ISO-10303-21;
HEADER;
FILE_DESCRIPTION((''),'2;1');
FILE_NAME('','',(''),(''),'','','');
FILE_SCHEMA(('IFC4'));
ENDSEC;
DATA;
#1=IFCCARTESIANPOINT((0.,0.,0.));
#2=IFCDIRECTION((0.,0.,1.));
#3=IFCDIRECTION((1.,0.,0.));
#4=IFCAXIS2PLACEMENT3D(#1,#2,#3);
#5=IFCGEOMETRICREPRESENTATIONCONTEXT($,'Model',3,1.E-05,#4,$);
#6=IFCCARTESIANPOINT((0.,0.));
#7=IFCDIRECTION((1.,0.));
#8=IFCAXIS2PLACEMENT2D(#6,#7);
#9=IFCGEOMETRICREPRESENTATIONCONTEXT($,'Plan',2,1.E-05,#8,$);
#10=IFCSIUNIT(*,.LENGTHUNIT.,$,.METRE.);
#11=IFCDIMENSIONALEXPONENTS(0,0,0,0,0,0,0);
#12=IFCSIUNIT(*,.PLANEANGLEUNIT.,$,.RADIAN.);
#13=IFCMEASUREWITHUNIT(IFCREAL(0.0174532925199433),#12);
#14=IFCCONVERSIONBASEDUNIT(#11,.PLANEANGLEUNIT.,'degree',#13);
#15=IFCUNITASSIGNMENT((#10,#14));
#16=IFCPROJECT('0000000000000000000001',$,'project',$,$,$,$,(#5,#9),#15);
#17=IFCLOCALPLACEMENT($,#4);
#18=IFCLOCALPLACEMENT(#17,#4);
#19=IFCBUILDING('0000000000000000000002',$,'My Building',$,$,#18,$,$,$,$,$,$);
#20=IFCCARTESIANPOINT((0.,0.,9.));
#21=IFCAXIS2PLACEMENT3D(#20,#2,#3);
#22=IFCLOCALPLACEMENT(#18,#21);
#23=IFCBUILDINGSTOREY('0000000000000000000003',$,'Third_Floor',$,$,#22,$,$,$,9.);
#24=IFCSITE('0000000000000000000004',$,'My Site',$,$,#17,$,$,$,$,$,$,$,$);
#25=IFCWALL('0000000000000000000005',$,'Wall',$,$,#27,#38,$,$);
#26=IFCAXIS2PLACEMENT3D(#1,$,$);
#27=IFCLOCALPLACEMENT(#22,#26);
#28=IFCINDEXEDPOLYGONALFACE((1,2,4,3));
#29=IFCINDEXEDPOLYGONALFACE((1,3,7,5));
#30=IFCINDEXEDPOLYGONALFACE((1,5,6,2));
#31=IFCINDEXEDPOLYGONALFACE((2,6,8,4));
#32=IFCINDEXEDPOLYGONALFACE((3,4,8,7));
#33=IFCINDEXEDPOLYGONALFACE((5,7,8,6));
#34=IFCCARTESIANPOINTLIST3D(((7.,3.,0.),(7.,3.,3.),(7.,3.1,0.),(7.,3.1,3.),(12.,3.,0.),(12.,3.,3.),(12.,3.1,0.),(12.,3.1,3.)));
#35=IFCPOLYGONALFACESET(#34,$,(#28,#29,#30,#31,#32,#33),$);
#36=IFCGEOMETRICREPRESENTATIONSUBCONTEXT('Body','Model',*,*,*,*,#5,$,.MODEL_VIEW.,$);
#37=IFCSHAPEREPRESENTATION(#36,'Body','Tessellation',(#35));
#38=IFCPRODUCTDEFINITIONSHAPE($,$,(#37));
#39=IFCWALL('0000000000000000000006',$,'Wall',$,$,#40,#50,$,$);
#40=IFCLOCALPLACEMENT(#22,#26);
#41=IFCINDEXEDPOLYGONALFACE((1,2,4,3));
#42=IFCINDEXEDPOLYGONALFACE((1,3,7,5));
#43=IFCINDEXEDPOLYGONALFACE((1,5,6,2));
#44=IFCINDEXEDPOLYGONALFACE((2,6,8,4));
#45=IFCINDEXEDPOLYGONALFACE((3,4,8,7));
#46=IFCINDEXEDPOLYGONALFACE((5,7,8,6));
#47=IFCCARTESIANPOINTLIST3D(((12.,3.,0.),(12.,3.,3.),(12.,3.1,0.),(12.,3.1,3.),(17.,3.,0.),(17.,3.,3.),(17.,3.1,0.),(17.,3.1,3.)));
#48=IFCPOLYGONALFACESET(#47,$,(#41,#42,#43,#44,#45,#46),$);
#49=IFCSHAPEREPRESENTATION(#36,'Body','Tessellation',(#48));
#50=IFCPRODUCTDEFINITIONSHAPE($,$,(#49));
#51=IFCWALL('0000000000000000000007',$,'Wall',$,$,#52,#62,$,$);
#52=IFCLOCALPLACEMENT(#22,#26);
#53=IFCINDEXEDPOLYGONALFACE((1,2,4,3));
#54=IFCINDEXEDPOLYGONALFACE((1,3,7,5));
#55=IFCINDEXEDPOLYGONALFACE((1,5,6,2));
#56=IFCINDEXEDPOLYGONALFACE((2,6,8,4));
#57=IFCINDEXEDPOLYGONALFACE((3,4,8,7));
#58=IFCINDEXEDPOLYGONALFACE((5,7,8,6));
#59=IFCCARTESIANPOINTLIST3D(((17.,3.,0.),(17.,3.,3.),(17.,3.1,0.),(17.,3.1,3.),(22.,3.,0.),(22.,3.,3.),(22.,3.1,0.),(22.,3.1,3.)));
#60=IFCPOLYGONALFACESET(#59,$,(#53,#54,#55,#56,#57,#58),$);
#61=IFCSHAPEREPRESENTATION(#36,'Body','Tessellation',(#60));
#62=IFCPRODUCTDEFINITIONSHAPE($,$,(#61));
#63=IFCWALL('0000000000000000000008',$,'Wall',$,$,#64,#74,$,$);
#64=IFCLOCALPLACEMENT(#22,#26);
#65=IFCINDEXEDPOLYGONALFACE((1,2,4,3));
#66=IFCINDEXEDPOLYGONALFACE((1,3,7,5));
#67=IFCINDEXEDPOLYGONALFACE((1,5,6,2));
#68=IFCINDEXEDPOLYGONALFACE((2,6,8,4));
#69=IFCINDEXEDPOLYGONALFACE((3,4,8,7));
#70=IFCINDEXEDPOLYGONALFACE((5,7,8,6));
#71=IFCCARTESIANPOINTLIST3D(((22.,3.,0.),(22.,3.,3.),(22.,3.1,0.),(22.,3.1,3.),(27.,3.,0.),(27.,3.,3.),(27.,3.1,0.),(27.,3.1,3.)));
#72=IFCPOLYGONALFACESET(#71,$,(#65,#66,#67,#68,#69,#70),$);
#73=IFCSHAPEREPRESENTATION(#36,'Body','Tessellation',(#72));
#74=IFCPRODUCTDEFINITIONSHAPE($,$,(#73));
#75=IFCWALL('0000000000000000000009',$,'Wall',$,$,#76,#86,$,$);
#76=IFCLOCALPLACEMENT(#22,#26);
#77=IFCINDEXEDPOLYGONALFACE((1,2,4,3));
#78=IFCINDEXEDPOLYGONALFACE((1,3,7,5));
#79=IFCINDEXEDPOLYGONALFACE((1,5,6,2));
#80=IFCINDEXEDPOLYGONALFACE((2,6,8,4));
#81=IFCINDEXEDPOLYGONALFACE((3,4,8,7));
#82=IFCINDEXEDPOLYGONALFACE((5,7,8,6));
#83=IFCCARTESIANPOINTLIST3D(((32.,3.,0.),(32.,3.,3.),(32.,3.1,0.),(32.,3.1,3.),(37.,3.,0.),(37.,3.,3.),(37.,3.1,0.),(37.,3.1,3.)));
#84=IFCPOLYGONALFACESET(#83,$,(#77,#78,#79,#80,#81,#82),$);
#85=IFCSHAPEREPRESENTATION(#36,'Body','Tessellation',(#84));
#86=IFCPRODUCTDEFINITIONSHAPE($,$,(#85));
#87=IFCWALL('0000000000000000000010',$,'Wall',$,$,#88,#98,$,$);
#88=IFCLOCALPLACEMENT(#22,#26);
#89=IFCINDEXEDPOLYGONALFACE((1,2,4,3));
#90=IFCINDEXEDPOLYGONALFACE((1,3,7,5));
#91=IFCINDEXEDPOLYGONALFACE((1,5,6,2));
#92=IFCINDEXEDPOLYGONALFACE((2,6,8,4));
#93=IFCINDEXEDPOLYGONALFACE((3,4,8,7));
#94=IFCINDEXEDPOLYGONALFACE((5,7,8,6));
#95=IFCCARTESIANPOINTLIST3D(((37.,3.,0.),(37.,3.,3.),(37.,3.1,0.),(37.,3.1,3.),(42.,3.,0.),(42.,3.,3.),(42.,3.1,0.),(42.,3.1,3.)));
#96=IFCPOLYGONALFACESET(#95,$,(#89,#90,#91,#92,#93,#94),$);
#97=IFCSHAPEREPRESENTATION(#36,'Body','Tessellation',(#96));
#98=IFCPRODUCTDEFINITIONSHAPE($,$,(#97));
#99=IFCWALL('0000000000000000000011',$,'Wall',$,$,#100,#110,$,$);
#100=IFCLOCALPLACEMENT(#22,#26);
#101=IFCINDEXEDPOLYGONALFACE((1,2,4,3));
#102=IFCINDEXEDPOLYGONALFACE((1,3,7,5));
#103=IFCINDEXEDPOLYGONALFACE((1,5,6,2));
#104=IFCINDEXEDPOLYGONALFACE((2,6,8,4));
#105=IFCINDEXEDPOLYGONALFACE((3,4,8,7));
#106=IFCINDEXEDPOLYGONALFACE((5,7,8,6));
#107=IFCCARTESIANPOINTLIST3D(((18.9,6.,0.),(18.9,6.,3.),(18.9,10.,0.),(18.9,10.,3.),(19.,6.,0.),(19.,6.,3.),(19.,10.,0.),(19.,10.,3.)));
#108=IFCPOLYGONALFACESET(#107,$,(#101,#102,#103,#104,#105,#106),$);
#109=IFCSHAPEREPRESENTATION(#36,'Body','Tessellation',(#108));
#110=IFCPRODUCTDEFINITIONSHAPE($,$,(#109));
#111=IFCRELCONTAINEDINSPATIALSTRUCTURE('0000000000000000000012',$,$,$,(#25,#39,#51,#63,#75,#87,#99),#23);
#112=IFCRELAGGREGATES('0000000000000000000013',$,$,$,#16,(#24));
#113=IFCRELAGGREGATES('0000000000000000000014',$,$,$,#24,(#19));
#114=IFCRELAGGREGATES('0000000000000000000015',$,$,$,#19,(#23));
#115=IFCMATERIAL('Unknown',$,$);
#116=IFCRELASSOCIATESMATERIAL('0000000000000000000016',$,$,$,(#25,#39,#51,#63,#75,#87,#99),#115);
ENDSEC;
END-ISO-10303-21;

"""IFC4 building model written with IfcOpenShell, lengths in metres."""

from ifc_helpers import new_model, entity, si_unit, converted_unit, frame, frame_2d, origin, origin_with_axes, origin_2d_with_axis, place, context, subcontext, project, spatial, rectangle, extrude, material, element, save


model = new_model("IFC4")

# Units and contexts
model_context = context("Model", 3, precision=1e-05, world=origin_with_axes())
plan_context = context("Plan", 2, precision=1e-05, world=origin_2d_with_axis())
body_context = subcontext(model_context, "Body", "Model", "MODEL_VIEW")
ifc_project = project(units=[si_unit("LENGTHUNIT", "METRE"), converted_unit("PLANEANGLEUNIT", "degree", entity("IfcReal", 0.0174532925199433), si_unit("PLANEANGLEUNIT", "RADIAN"), dimensions=[0, 0, 0, 0, 0, 0, 0])], contexts=[model_context, plan_context])

# Site, building, storey
site_placement = place(None, origin_with_axes())
site = spatial("IfcSite", under=ifc_project, at=site_placement, Name="My Site")
building_placement = place(site_placement, origin_with_axes())
building = spatial("IfcBuilding", under=site, at=building_placement, Name="My Building")
storey_placement = place(building_placement, frame((0.0, 0.0, 9.0), z_axis=(0.0, 0.0, 1.0), x_axis=(1.0, 0.0, 0.0)))
storey = spatial("IfcBuildingStorey", under=building, at=storey_placement, Name="Third_Floor", Elevation=9.0)

# Walls
ifc_material = material(Name="Unknown")
wall_1_placement = place(storey_placement, origin_with_axes())
element("IfcWall", 1, at=wall_1_placement, inside=storey, material=ifc_material, Name="Wall", context=body_context, shape_type="SweptSolid", body=[
    extrude(rectangle(XDim=5.0, YDim=0.1, at=frame_2d((9.5, 3.05))), origin(), (0.0, 0.0, 1.0), 3.0),
])
wall_2_placement = place(storey_placement, origin_with_axes())
element("IfcWall", 2, at=wall_2_placement, inside=storey, material=ifc_material, Name="Wall", context=body_context, shape_type="SweptSolid", body=[
    extrude(rectangle(XDim=5.0, YDim=0.1, at=frame_2d((14.5, 3.05))), origin(), (0.0, 0.0, 1.0), 3.0),
])
wall_3_placement = place(storey_placement, origin_with_axes())
element("IfcWall", 3, at=wall_3_placement, inside=storey, material=ifc_material, Name="Wall", context=body_context, shape_type="SweptSolid", body=[
    extrude(rectangle(XDim=5.0, YDim=0.1, at=frame_2d((19.5, 3.05))), origin(), (0.0, 0.0, 1.0), 3.0),
])
wall_4_placement = place(storey_placement, origin_with_axes())
element("IfcWall", 4, at=wall_4_placement, inside=storey, material=ifc_material, Name="Wall", context=body_context, shape_type="SweptSolid", body=[
    extrude(rectangle(XDim=5.0, YDim=0.1, at=frame_2d((24.5, 3.05))), origin(), (0.0, 0.0, 1.0), 3.0),
])
wall_5_placement = place(storey_placement, origin_with_axes())
element("IfcWall", 5, at=wall_5_placement, inside=storey, material=ifc_material, Name="Wall", context=body_context, shape_type="SweptSolid", body=[
    extrude(rectangle(XDim=5.0, YDim=0.1, at=frame_2d((34.5, 3.05))), origin(), (0.0, 0.0, 1.0), 3.0),
])
wall_6_placement = place(storey_placement, origin_with_axes())
element("IfcWall", 6, at=wall_6_placement, inside=storey, material=ifc_material, Name="Wall", context=body_context, shape_type="SweptSolid", body=[
    extrude(rectangle(XDim=5.0, YDim=0.1, at=frame_2d((39.5, 3.05))), origin(), (0.0, 0.0, 1.0), 3.0),
])
wall_7_placement = place(storey_placement, origin_with_axes())
element("IfcWall", 7, at=wall_7_placement, inside=storey, material=ifc_material, Name="Wall", context=body_context, shape_type="SweptSolid", body=[
    extrude(rectangle(XDim=0.1, YDim=4.0, at=frame_2d((18.95, 8.0))), origin(), (0.0, 0.0, 1.0), 3.0),
])

save(model, "model.ifc")
